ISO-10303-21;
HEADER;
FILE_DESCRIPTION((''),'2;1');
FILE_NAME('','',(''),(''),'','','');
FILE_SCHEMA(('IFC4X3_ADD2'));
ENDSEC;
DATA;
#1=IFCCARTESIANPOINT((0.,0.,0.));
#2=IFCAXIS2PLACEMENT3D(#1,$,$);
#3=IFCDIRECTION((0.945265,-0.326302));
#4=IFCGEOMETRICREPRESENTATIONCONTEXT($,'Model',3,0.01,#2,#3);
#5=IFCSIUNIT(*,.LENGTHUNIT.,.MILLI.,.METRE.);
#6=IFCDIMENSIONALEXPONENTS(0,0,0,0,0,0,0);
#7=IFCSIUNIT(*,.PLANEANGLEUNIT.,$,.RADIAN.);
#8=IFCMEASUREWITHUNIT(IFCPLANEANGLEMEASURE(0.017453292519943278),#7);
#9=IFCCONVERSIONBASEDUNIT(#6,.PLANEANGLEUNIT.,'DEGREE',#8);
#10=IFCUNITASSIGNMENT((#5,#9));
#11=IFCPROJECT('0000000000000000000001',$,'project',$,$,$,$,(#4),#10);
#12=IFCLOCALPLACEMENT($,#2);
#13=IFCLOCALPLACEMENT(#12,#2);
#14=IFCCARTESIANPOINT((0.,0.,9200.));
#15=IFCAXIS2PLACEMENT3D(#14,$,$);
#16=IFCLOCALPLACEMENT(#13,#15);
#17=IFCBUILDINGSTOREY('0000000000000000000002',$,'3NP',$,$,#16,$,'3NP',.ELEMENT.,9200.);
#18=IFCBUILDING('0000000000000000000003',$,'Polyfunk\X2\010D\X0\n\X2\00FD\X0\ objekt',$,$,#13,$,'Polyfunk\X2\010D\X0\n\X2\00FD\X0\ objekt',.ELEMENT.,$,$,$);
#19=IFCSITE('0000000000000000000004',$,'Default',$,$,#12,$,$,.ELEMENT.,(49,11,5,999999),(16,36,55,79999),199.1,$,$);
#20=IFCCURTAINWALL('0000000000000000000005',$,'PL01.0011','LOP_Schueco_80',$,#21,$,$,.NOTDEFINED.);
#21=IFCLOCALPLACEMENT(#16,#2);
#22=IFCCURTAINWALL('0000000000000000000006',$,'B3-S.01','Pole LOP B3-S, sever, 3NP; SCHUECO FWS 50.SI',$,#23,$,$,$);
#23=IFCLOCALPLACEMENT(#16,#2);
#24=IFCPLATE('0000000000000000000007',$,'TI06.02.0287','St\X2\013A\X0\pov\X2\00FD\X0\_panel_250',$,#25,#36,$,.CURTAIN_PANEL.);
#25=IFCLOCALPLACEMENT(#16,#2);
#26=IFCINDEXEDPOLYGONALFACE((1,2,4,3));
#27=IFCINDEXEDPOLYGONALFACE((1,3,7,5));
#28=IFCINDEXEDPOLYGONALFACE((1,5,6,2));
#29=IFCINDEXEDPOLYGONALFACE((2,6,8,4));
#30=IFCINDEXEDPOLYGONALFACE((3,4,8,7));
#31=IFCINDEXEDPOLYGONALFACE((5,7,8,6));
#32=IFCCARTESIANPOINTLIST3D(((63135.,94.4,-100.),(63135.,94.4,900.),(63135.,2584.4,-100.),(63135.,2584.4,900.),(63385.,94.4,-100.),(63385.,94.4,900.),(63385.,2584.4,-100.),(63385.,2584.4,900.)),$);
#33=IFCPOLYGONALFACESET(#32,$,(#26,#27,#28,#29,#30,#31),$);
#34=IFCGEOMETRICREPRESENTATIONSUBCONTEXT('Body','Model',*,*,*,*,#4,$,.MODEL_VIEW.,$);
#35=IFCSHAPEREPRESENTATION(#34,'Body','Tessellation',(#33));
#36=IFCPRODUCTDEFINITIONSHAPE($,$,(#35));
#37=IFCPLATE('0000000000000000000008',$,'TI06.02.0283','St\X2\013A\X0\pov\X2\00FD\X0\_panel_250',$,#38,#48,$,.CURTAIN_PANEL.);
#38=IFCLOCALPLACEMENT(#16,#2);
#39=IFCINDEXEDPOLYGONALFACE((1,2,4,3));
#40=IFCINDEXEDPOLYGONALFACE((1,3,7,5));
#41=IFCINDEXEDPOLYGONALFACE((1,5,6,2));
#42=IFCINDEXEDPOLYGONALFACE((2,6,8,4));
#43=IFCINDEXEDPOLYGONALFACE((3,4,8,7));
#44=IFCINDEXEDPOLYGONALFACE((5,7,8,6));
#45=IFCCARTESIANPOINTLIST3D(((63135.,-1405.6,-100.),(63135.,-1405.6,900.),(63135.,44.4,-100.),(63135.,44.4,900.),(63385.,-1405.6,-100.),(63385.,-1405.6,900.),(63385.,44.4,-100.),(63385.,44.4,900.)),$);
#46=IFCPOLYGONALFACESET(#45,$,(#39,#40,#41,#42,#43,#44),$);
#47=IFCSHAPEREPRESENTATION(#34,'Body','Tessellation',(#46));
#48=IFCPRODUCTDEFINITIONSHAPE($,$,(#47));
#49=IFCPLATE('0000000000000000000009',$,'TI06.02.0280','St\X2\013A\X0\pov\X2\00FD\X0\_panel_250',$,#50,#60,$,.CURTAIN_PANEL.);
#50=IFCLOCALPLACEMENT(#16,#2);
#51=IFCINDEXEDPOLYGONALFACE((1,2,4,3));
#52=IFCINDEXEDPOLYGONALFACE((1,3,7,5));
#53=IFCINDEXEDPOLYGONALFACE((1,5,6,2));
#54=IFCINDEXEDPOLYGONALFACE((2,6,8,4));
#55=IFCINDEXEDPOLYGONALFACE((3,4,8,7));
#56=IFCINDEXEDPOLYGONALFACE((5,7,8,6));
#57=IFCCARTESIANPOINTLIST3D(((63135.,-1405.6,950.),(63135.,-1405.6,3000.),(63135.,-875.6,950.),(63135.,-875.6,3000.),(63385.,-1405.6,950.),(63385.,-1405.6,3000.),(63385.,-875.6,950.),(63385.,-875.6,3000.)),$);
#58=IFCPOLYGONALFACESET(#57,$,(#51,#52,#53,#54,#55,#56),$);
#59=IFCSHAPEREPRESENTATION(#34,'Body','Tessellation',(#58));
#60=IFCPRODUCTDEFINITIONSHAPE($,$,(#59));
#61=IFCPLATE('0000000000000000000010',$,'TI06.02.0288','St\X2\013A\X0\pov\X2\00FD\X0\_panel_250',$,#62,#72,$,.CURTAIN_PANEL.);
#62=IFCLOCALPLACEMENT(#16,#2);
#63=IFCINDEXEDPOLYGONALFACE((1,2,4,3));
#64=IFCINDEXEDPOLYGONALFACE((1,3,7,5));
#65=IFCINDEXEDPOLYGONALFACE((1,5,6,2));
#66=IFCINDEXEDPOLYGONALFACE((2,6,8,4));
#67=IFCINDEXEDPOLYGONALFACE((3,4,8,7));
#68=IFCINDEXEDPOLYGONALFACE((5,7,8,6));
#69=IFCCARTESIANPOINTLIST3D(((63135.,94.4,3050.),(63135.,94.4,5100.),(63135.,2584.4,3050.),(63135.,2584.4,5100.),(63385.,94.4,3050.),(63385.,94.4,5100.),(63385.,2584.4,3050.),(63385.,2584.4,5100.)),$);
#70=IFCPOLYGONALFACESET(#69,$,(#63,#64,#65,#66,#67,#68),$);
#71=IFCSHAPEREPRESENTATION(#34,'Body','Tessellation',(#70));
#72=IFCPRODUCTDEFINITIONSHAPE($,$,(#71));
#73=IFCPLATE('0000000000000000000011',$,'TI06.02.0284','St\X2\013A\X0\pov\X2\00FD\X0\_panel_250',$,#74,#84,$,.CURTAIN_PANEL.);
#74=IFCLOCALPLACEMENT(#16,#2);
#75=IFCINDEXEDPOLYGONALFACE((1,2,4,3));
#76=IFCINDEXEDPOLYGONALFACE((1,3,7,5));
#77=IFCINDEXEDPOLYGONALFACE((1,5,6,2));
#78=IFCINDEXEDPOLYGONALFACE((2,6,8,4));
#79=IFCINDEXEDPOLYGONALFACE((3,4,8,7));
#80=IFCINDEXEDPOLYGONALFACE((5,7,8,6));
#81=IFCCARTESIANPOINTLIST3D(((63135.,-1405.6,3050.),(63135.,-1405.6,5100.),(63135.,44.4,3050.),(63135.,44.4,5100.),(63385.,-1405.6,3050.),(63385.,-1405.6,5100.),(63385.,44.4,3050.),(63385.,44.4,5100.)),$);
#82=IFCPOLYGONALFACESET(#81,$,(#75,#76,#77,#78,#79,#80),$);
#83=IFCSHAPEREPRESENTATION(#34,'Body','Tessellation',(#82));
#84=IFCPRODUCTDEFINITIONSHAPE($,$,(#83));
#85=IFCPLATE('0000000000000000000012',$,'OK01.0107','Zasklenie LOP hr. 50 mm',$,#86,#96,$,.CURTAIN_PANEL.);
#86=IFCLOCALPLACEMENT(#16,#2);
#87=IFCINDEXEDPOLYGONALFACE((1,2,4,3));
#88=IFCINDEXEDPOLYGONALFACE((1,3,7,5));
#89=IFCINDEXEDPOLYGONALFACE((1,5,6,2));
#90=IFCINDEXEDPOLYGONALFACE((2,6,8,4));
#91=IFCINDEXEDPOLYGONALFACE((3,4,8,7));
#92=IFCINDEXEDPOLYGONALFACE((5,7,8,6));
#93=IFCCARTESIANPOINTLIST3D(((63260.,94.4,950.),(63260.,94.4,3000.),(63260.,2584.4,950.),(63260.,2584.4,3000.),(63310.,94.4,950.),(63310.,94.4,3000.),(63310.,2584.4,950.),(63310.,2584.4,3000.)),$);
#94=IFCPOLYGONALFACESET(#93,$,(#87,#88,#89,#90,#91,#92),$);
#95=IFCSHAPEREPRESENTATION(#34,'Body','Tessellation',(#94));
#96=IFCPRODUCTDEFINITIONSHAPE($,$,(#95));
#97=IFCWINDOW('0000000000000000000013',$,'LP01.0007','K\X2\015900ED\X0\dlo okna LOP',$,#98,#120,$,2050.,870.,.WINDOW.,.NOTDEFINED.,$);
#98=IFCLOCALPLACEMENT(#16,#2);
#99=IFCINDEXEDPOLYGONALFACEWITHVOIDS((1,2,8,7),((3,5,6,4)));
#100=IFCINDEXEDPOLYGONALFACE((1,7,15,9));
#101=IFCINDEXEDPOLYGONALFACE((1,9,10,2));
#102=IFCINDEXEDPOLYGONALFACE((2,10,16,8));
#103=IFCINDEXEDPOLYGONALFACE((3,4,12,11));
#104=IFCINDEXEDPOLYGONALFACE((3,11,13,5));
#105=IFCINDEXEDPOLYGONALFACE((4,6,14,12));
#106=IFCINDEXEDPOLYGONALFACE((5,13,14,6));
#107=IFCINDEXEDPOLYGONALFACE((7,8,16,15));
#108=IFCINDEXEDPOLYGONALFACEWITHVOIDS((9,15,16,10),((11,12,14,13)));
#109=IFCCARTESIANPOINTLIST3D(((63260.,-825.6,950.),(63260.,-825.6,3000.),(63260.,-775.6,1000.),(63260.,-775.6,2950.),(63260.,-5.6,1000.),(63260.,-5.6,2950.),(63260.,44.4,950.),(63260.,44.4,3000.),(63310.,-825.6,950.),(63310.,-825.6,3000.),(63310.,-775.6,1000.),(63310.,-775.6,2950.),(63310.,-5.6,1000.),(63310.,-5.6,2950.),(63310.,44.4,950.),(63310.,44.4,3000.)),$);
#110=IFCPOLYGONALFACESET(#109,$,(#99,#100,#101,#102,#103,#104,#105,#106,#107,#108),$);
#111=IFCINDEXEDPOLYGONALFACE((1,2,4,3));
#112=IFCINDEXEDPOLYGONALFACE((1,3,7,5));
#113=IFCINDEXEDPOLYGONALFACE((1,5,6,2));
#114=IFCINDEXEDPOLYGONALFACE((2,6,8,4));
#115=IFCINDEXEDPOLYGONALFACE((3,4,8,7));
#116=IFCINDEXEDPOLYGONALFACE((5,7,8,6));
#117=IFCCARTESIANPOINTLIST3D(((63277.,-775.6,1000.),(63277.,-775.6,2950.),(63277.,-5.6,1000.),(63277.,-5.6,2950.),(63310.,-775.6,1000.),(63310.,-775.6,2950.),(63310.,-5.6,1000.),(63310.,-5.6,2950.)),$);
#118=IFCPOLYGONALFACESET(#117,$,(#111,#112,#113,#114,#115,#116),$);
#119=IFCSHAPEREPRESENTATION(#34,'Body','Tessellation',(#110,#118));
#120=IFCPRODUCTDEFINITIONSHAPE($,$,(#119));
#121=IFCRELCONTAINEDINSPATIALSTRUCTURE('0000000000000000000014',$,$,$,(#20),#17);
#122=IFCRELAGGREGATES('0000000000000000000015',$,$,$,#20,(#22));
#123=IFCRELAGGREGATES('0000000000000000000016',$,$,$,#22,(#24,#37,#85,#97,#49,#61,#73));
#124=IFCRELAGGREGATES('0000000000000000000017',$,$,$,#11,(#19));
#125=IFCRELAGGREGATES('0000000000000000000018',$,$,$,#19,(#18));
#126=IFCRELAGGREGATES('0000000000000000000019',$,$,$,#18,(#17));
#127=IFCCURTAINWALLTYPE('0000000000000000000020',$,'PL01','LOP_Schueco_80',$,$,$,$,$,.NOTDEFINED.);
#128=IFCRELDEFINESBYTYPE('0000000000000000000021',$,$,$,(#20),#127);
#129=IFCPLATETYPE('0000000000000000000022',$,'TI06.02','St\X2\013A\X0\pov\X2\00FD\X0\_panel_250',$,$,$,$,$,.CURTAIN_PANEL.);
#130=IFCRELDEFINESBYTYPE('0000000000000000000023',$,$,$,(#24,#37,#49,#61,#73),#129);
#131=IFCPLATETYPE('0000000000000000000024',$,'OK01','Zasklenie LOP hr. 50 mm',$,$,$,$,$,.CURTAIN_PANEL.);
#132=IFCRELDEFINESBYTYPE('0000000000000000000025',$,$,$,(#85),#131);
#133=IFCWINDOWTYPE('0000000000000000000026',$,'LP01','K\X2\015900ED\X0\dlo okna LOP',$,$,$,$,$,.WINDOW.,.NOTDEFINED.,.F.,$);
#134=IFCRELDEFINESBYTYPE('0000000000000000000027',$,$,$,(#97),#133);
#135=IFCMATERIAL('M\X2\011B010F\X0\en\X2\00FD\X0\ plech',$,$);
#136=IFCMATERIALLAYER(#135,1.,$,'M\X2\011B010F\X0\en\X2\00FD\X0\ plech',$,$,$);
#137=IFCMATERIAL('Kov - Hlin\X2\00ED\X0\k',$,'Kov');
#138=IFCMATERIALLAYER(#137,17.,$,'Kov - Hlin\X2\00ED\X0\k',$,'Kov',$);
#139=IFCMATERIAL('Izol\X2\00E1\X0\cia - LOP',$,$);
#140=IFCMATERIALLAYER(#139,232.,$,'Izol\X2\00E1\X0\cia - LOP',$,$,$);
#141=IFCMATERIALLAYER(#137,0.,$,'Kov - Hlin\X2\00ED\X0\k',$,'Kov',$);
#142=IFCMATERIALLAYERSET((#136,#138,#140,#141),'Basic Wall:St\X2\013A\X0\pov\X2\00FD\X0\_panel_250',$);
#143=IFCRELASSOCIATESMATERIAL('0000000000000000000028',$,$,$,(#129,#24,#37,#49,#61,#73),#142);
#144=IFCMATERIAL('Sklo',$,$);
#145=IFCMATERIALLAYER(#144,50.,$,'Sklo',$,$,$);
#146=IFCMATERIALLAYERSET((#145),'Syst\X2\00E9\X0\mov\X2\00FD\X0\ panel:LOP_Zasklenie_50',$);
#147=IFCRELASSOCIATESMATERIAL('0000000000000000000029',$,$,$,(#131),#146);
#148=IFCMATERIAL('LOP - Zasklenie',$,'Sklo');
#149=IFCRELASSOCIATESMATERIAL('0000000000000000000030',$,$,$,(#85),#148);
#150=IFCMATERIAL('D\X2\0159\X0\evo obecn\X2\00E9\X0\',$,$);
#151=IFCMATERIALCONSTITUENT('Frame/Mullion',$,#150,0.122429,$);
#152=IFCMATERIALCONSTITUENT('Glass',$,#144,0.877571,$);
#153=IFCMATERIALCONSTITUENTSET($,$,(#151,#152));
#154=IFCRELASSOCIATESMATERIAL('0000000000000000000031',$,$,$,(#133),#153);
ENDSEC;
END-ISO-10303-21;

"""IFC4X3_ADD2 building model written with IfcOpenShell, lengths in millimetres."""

from ifc_helpers import new_model, entity, si_unit, converted_unit, direction, frame, frame_2d, origin, origin_2d_with_axis, place, context, subcontext, project, spatial, polyline, rectangle, outline, extrude, source, transform, mapped, material, layer, layer_set, layer_usage, constituent, constituent_set, type_object, type_shapes, element, aggregate, save


model = new_model("IFC4X3_ADD2")

# Units and contexts
model_context = context("Model", 3, precision=0.01, world=origin(), true_north=direction((0.945265, -0.326302)))
body_context = subcontext(model_context, "Body", "Model", "MODEL_VIEW")
ifc_project = project(units=[si_unit("LENGTHUNIT", "METRE", prefix="MILLI"), converted_unit("PLANEANGLEUNIT", "DEGREE", entity("IfcPlaneAngleMeasure", 0.017453292519943278), si_unit("PLANEANGLEUNIT", "RADIAN"), dimensions=[0, 0, 0, 0, 0, 0, 0])], contexts=[model_context])

# Site, building, storey
site_placement = place(None, origin())
site = spatial("IfcSite", under=ifc_project, at=site_placement, Name="Default", CompositionType="ELEMENT", RefLatitude=(49, 11, 5, 999999), RefLongitude=(16, 36, 55, 79999), RefElevation=199.1)
building_placement = place(site_placement, origin())
building = spatial("IfcBuilding", under=site, at=building_placement, Name="Polyfunkčný objekt", LongName="Polyfunkčný objekt", CompositionType="ELEMENT")
storey_placement = place(building_placement, frame((0.0, 0.0, 9200.0)))
storey = spatial("IfcBuildingStorey", under=building, at=storey_placement, Name="3NP", LongName="3NP", CompositionType="ELEMENT", Elevation=9200.0)

# Curtain walls, plates, window
curtain_wall_type = type_object("IfcCurtainWallType", Name="PL01", Description="LOP_Schueco_80", PredefinedType="NOTDEFINED")
curtain_wall_1_placement = place(storey_placement, frame((0.0, 0.0, -9200.0)))
curtain_wall_1 = element("IfcCurtainWall", 1, at=curtain_wall_1_placement, inside=storey, type_object=curtain_wall_type, Name="PL01.0011", Description="LOP_Schueco_80", PredefinedType="NOTDEFINED")
curtain_wall_2 = element("IfcCurtainWall", 2, Name="B3-S.01", Description="Pole LOP B3-S, sever, 3NP; SCHUECO FWS 50.SI")
aggregate(curtain_wall_1, [curtain_wall_2])
ifc_material_1 = material(Name="Měďený plech")
ifc_layer_1 = layer(ifc_material_1, 1.0, Name="Měďený plech")
ifc_material_2 = material(Name="Kov - Hliník", Category="Kov")
ifc_layer_2 = layer(ifc_material_2, 17.0, Name="Kov - Hliník", Category="Kov")
ifc_material_3 = material(Name="Izolácia - LOP")
ifc_layer_3 = layer(ifc_material_3, 232.0, Name="Izolácia - LOP")
ifc_layer_4 = layer(ifc_material_2, 0.0, Name="Kov - Hliník", Category="Kov")
ifc_layer_set_1 = layer_set([ifc_layer_1, ifc_layer_2, ifc_layer_3, ifc_layer_4], Name="Basic Wall:Stĺpový_panel_250")
ifc_layer_usage_1 = layer_usage(ifc_layer_set_1, "AXIS2", "NEGATIVE", 125.0)
plate_type_1 = type_object("IfcPlateType", Name="TI06.02", Description="Stĺpový_panel_250", PredefinedType="CURTAIN_PANEL", material=ifc_layer_set_1)
plate_1_placement = place(storey_placement, frame((63260.0, 2584.4, -100.0), z_axis=(0.0, 0.0, 1.0), x_axis=(0.0, -1.0, 0.0)))
plate_1 = element("IfcPlate", 3, at=plate_1_placement, type_object=plate_type_1, material=ifc_layer_usage_1, Name="TI06.02.0287", Description="Stĺpový_panel_250", PredefinedType="CURTAIN_PANEL", context=body_context, shape_type="SweptSolid", body=[
    extrude(rectangle(XDim=250.0, YDim=2490.0, at=frame_2d((0.0, 0.0), x_axis=(1.0, 0.0))), frame((1245.0, 0.0, 0.0), z_axis=(0.0, 0.0, 1.0), x_axis=(0.0, 1.0, 0.0)), (0.0, 0.0, 1.0), 1000.0),
])
ifc_layer_usage_2 = layer_usage(ifc_layer_set_1, "AXIS2", "NEGATIVE", 125.0)
plate_2_placement = place(storey_placement, frame((63260.0, 44.4, -100.0), z_axis=(0.0, 0.0, 1.0), x_axis=(0.0, -1.0, 0.0)))
plate_2 = element("IfcPlate", 4, at=plate_2_placement, type_object=plate_type_1, material=ifc_layer_usage_2, Name="TI06.02.0283", Description="Stĺpový_panel_250", PredefinedType="CURTAIN_PANEL", context=body_context, shape_type="SweptSolid", body=[
    extrude(rectangle(XDim=250.0, YDim=1450.0, at=frame_2d((0.0, 0.0), x_axis=(1.0, 0.0))), frame((725.0, 0.0, 0.0), z_axis=(0.0, 0.0, 1.0), x_axis=(0.0, 1.0, 0.0)), (0.0, 0.0, 1.0), 1000.0),
])
ifc_layer_usage_3 = layer_usage(ifc_layer_set_1, "AXIS2", "NEGATIVE", 125.0)
plate_3_placement = place(storey_placement, frame((63260.0, -875.6, 950.0), z_axis=(0.0, 0.0, 1.0), x_axis=(0.0, -1.0, 0.0)))
plate_3 = element("IfcPlate", 5, at=plate_3_placement, type_object=plate_type_1, material=ifc_layer_usage_3, Name="TI06.02.0280", Description="Stĺpový_panel_250", PredefinedType="CURTAIN_PANEL", context=body_context, shape_type="SweptSolid", body=[
    extrude(rectangle(XDim=250.0, YDim=530.0, at=frame_2d((0.0, 0.0), x_axis=(1.0, 0.0))), frame((265.0, 0.0, 0.0), z_axis=(0.0, 0.0, 1.0), x_axis=(0.0, 1.0, 0.0)), (0.0, 0.0, 1.0), 2050.0),
])
ifc_layer_usage_4 = layer_usage(ifc_layer_set_1, "AXIS2", "NEGATIVE", 125.0)
plate_4_placement = place(storey_placement, frame((63260.0, 2584.4, 3050.0), z_axis=(0.0, 0.0, 1.0), x_axis=(0.0, -1.0, 0.0)))
plate_4 = element("IfcPlate", 6, at=plate_4_placement, type_object=plate_type_1, material=ifc_layer_usage_4, Name="TI06.02.0288", Description="Stĺpový_panel_250", PredefinedType="CURTAIN_PANEL", context=body_context, shape_type="SweptSolid", body=[
    extrude(rectangle(XDim=250.0, YDim=2490.0, at=frame_2d((0.0, 0.0), x_axis=(1.0, 0.0))), frame((1245.0, 0.0, 0.0), z_axis=(0.0, 0.0, 1.0), x_axis=(0.0, 1.0, 0.0)), (0.0, 0.0, 1.0), 2050.0),
])
ifc_layer_usage_5 = layer_usage(ifc_layer_set_1, "AXIS2", "NEGATIVE", 125.0)
plate_5_placement = place(storey_placement, frame((63260.0, 44.4, 3050.0), z_axis=(0.0, 0.0, 1.0), x_axis=(0.0, -1.0, 0.0)))
plate_5 = element("IfcPlate", 7, at=plate_5_placement, type_object=plate_type_1, material=ifc_layer_usage_5, Name="TI06.02.0284", Description="Stĺpový_panel_250", PredefinedType="CURTAIN_PANEL", context=body_context, shape_type="SweptSolid", body=[
    extrude(rectangle(XDim=250.0, YDim=1450.0, at=frame_2d((0.0, 0.0), x_axis=(1.0, 0.0))), frame((725.0, 0.0, 0.0), z_axis=(0.0, 0.0, 1.0), x_axis=(0.0, 1.0, 0.0)), (0.0, 0.0, 1.0), 2050.0),
])
ifc_material_4 = material(Name="LOP - Zasklenie", Category="Sklo")
ifc_material_5 = material(Name="Sklo")
ifc_layer_5 = layer(ifc_material_5, 50.0, Name="Sklo")
ifc_layer_set_2 = layer_set([ifc_layer_5], Name="Systémový panel:LOP_Zasklenie_50")
plate_type_2 = type_object("IfcPlateType", Name="OK01", Description="Zasklenie LOP hr. 50 mm", PredefinedType="CURTAIN_PANEL", material=ifc_layer_set_2)
shared_shape_1 = source(origin(), body_context, "Body", "SweptSolid", [
    extrude(rectangle(XDim=50.0, YDim=2490.0, at=origin_2d_with_axis()), frame((0.0, 25.0, 0.0), z_axis=(0.0, 0.0, 1.0), x_axis=(0.0, 1.0, 0.0)), (0.0, 0.0, 1.0), 2050.0),
])
type_shapes(plate_type_2, [shared_shape_1])
plate_6_placement = place(curtain_wall_1_placement, frame((63260.0, 1339.4, 10150.0), z_axis=(0.0, 0.0, 1.0), x_axis=(0.0, -1.0, 0.0)))
plate_6 = element("IfcPlate", 8, at=plate_6_placement, type_object=plate_type_2, material=ifc_material_4, Name="OK01.0107", Description="Zasklenie LOP hr. 50 mm", PredefinedType="CURTAIN_PANEL", context=body_context, shape_type="MappedRepresentation", body=[
    mapped(shared_shape_1, transform((0.0, 0.0, 0.0), scale=1.0)),
])
ifc_material_6 = material(Name="Dřevo obecné")
ifc_constituent_1 = constituent(ifc_material_6, Name="Frame/Mullion", fraction=0.122429)
ifc_constituent_2 = constituent(ifc_material_5, Name="Glass", fraction=0.877571)
ifc_constituent_set = constituent_set(constituents=[ifc_constituent_1, ifc_constituent_2])
window_type = type_object("IfcWindowType", Name="LP01", Description="Křídlo okna LOP", ParameterTakesPrecedence=False, PartitioningType="NOTDEFINED", PredefinedType="WINDOW", material=ifc_constituent_set)
shared_shape_2 = source(origin(), body_context, "Body", "SweptSolid", [
    extrude(outline(polyline([(-1025.0, -435.0), (1025.0, -435.0), (1025.0, 435.0), (-1025.0, 435.0), (-1025.0, -435.0)]), holes=[polyline([(-975.0, -385.0), (-975.0, 385.0), (975.0, 385.0), (975.0, -385.0), (-975.0, -385.0)])]), frame((0.0, 0.0, 1025.0), z_axis=(0.0, 1.0, 0.0), x_axis=(0.0, 0.0, -1.0)), (0.0, 0.0, 1.0), 50.0),
    extrude(rectangle(XDim=33.0, YDim=770.0, at=origin_2d_with_axis()), frame((0.0, 33.5, 50.0), z_axis=(0.0, 0.0, 1.0), x_axis=(0.0, -1.0, 0.0)), (0.0, 0.0, 1.0), 1950.0),
])
type_shapes(window_type, [shared_shape_2])
window_placement = place(curtain_wall_1_placement, frame((63260.0, -390.6, 10150.0), z_axis=(0.0, 0.0, 1.0), x_axis=(0.0, -1.0, 0.0)))
window = element("IfcWindow", 9, at=window_placement, type_object=window_type, Name="LP01.0007", Description="Křídlo okna LOP", OverallHeight=2050.0, OverallWidth=870.0, PartitioningType="NOTDEFINED", PredefinedType="WINDOW", context=body_context, shape_type="MappedRepresentation", body=[
    mapped(shared_shape_2, transform((0.0, 0.0, 0.0), scale=1.0)),
])
aggregate(curtain_wall_2, [plate_1, plate_2, plate_6, window, plate_3, plate_4, plate_5])

save(model, "model.ifc")
